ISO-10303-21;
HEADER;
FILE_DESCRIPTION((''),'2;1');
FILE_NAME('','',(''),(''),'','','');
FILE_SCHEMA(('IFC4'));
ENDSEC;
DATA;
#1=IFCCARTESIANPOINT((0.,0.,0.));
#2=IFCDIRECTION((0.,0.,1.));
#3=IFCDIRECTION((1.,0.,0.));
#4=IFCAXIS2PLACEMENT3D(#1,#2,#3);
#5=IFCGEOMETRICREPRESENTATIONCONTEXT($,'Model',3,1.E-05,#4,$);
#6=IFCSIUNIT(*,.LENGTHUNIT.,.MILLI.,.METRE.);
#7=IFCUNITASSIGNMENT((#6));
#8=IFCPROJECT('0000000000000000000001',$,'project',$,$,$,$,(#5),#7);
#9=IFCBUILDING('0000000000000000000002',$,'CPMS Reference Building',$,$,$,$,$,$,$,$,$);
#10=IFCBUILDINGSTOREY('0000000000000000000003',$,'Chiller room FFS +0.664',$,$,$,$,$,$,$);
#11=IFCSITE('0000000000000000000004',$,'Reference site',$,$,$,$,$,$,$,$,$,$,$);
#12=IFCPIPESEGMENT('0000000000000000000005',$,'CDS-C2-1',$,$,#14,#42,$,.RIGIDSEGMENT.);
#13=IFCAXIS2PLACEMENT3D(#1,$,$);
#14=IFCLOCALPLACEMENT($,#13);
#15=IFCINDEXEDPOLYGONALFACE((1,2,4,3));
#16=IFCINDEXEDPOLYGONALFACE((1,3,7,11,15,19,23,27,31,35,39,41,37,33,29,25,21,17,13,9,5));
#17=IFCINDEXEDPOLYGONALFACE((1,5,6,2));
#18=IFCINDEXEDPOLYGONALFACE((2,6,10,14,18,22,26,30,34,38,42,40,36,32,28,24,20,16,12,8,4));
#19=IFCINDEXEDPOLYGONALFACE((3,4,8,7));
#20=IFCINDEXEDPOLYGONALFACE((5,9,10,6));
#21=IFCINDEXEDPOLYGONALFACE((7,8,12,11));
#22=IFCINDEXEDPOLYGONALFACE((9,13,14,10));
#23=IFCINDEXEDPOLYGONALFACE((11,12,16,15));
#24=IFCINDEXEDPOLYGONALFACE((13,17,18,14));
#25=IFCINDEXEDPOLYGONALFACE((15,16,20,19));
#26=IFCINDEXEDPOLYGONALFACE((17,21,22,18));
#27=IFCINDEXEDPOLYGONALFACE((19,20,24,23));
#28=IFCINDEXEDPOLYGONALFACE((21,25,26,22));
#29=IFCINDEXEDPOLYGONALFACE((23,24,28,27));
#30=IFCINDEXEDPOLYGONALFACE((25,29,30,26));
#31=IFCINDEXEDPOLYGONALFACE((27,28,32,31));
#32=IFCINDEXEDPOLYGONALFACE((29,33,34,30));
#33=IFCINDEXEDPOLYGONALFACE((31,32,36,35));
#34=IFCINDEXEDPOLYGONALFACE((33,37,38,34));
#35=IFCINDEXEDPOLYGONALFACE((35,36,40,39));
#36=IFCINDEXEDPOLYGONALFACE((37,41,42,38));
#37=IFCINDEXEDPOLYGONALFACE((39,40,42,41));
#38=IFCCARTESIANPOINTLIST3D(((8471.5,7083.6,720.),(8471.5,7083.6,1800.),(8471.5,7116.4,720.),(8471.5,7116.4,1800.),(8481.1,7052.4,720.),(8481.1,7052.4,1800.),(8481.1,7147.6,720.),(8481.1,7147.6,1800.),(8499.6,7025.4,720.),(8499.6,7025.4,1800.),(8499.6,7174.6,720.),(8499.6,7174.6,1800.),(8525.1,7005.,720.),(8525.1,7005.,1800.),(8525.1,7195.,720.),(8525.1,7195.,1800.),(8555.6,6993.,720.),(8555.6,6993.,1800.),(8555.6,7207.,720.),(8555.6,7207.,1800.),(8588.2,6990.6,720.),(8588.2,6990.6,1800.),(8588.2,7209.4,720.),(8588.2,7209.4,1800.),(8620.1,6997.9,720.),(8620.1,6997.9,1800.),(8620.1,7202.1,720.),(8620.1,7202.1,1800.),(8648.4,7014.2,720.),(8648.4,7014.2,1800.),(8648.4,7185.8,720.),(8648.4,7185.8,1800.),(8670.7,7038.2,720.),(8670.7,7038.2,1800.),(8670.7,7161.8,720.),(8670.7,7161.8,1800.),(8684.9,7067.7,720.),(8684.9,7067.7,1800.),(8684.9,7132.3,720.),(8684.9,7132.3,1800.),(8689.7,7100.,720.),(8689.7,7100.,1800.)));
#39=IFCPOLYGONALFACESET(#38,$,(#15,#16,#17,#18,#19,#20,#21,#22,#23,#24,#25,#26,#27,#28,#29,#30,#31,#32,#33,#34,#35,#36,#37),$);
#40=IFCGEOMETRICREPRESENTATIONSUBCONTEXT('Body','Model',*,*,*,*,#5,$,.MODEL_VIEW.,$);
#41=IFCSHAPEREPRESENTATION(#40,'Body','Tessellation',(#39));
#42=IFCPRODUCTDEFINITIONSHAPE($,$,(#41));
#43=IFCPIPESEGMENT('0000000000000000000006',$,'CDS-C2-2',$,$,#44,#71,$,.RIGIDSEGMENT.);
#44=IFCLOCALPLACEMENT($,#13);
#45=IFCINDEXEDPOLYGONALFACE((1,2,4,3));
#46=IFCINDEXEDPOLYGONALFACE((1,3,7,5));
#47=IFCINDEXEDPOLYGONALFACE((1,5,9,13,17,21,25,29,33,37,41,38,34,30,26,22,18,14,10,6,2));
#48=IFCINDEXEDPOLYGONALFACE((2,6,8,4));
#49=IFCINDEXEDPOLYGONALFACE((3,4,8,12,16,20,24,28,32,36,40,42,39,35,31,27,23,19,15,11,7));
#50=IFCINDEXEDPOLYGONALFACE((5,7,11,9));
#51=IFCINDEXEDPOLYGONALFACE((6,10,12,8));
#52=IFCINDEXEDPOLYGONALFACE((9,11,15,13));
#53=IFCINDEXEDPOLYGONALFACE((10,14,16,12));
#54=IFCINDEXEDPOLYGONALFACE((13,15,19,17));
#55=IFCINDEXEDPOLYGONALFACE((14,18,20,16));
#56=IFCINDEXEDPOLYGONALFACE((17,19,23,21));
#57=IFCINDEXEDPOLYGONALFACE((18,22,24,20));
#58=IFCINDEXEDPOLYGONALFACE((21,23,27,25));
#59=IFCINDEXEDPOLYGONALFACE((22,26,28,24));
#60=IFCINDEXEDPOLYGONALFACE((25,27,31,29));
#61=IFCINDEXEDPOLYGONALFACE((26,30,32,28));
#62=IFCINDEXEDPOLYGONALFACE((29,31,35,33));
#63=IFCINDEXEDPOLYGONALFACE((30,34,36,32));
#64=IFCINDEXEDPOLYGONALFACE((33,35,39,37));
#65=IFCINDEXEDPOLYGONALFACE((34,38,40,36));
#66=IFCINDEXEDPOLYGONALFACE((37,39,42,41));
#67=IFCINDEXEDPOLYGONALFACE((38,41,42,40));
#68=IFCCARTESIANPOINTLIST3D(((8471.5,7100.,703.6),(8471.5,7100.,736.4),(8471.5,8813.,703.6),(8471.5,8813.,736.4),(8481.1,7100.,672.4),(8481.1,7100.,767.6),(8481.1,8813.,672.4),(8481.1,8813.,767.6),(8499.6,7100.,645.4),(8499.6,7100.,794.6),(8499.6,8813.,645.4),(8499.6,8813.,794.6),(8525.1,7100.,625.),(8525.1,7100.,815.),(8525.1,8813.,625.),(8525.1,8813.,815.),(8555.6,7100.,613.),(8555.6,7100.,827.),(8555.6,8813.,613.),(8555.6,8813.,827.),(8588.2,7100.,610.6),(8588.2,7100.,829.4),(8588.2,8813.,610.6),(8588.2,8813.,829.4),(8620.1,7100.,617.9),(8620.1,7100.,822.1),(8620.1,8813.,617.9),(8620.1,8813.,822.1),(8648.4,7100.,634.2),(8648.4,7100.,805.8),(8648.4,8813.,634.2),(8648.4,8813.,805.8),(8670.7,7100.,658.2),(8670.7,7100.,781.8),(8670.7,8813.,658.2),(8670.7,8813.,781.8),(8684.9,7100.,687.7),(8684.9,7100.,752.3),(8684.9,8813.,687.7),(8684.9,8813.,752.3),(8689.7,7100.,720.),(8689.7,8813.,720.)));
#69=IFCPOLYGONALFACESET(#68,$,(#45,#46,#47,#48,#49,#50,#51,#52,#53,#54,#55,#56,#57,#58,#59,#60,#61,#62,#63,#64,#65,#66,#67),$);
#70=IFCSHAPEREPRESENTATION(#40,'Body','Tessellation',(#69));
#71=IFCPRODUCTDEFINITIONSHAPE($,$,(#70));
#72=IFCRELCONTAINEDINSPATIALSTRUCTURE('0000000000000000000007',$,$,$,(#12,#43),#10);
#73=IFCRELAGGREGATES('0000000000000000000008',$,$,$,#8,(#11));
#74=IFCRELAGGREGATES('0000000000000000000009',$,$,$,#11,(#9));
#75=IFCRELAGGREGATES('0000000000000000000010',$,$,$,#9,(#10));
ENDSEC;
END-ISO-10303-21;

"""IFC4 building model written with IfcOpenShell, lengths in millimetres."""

from ifc_helpers import new_model, si_unit, frame, origin_with_axes, origin_2d, place, context, subcontext, project, spatial, circle_curve, outline, extrude, element, save


model = new_model("IFC4")

# Units and contexts
model_context = context("Model", 3, precision=1e-05, world=origin_with_axes())
body_context = subcontext(model_context, "Body", "Model", "MODEL_VIEW")
ifc_project = project(units=[si_unit("LENGTHUNIT", "METRE", prefix="MILLI")], contexts=[model_context])

# Site, building, storey
site = spatial("IfcSite", under=ifc_project, Name="Reference site")
building = spatial("IfcBuilding", under=site, Name="CPMS Reference Building")
storey = spatial("IfcBuildingStorey", under=building, Name="Chiller room FFS +0.664")

# Pipe segments
pipe_segment_1_placement = place(None, origin_with_axes())
element("IfcPipeSegment", 1, at=pipe_segment_1_placement, inside=storey, Name="CDS-C2-1", PredefinedType="RIGIDSEGMENT", context=body_context, shape_type="SweptSolid", body=[
    extrude(outline(circle_curve(origin_2d(), 109.7)), frame((8580.0, 7100.0, 1800.0), z_axis=(0.0, 0.0, -1.0), x_axis=(1.0, 0.0, 0.0)), (0.0, 0.0, 1.0), 1080.0),
])
pipe_segment_2_placement = place(None, origin_with_axes())
element("IfcPipeSegment", 2, at=pipe_segment_2_placement, inside=storey, Name="CDS-C2-2", PredefinedType="RIGIDSEGMENT", context=body_context, shape_type="SweptSolid", body=[
    extrude(outline(circle_curve(origin_2d(), 109.7)), frame((8580.0, 7100.0, 720.0), z_axis=(0.0, 1.0, 0.0), x_axis=(1.0, 0.0, 0.0)), (0.0, 0.0, 1.0), 1713.0),
])

save(model, "model.ifc")
